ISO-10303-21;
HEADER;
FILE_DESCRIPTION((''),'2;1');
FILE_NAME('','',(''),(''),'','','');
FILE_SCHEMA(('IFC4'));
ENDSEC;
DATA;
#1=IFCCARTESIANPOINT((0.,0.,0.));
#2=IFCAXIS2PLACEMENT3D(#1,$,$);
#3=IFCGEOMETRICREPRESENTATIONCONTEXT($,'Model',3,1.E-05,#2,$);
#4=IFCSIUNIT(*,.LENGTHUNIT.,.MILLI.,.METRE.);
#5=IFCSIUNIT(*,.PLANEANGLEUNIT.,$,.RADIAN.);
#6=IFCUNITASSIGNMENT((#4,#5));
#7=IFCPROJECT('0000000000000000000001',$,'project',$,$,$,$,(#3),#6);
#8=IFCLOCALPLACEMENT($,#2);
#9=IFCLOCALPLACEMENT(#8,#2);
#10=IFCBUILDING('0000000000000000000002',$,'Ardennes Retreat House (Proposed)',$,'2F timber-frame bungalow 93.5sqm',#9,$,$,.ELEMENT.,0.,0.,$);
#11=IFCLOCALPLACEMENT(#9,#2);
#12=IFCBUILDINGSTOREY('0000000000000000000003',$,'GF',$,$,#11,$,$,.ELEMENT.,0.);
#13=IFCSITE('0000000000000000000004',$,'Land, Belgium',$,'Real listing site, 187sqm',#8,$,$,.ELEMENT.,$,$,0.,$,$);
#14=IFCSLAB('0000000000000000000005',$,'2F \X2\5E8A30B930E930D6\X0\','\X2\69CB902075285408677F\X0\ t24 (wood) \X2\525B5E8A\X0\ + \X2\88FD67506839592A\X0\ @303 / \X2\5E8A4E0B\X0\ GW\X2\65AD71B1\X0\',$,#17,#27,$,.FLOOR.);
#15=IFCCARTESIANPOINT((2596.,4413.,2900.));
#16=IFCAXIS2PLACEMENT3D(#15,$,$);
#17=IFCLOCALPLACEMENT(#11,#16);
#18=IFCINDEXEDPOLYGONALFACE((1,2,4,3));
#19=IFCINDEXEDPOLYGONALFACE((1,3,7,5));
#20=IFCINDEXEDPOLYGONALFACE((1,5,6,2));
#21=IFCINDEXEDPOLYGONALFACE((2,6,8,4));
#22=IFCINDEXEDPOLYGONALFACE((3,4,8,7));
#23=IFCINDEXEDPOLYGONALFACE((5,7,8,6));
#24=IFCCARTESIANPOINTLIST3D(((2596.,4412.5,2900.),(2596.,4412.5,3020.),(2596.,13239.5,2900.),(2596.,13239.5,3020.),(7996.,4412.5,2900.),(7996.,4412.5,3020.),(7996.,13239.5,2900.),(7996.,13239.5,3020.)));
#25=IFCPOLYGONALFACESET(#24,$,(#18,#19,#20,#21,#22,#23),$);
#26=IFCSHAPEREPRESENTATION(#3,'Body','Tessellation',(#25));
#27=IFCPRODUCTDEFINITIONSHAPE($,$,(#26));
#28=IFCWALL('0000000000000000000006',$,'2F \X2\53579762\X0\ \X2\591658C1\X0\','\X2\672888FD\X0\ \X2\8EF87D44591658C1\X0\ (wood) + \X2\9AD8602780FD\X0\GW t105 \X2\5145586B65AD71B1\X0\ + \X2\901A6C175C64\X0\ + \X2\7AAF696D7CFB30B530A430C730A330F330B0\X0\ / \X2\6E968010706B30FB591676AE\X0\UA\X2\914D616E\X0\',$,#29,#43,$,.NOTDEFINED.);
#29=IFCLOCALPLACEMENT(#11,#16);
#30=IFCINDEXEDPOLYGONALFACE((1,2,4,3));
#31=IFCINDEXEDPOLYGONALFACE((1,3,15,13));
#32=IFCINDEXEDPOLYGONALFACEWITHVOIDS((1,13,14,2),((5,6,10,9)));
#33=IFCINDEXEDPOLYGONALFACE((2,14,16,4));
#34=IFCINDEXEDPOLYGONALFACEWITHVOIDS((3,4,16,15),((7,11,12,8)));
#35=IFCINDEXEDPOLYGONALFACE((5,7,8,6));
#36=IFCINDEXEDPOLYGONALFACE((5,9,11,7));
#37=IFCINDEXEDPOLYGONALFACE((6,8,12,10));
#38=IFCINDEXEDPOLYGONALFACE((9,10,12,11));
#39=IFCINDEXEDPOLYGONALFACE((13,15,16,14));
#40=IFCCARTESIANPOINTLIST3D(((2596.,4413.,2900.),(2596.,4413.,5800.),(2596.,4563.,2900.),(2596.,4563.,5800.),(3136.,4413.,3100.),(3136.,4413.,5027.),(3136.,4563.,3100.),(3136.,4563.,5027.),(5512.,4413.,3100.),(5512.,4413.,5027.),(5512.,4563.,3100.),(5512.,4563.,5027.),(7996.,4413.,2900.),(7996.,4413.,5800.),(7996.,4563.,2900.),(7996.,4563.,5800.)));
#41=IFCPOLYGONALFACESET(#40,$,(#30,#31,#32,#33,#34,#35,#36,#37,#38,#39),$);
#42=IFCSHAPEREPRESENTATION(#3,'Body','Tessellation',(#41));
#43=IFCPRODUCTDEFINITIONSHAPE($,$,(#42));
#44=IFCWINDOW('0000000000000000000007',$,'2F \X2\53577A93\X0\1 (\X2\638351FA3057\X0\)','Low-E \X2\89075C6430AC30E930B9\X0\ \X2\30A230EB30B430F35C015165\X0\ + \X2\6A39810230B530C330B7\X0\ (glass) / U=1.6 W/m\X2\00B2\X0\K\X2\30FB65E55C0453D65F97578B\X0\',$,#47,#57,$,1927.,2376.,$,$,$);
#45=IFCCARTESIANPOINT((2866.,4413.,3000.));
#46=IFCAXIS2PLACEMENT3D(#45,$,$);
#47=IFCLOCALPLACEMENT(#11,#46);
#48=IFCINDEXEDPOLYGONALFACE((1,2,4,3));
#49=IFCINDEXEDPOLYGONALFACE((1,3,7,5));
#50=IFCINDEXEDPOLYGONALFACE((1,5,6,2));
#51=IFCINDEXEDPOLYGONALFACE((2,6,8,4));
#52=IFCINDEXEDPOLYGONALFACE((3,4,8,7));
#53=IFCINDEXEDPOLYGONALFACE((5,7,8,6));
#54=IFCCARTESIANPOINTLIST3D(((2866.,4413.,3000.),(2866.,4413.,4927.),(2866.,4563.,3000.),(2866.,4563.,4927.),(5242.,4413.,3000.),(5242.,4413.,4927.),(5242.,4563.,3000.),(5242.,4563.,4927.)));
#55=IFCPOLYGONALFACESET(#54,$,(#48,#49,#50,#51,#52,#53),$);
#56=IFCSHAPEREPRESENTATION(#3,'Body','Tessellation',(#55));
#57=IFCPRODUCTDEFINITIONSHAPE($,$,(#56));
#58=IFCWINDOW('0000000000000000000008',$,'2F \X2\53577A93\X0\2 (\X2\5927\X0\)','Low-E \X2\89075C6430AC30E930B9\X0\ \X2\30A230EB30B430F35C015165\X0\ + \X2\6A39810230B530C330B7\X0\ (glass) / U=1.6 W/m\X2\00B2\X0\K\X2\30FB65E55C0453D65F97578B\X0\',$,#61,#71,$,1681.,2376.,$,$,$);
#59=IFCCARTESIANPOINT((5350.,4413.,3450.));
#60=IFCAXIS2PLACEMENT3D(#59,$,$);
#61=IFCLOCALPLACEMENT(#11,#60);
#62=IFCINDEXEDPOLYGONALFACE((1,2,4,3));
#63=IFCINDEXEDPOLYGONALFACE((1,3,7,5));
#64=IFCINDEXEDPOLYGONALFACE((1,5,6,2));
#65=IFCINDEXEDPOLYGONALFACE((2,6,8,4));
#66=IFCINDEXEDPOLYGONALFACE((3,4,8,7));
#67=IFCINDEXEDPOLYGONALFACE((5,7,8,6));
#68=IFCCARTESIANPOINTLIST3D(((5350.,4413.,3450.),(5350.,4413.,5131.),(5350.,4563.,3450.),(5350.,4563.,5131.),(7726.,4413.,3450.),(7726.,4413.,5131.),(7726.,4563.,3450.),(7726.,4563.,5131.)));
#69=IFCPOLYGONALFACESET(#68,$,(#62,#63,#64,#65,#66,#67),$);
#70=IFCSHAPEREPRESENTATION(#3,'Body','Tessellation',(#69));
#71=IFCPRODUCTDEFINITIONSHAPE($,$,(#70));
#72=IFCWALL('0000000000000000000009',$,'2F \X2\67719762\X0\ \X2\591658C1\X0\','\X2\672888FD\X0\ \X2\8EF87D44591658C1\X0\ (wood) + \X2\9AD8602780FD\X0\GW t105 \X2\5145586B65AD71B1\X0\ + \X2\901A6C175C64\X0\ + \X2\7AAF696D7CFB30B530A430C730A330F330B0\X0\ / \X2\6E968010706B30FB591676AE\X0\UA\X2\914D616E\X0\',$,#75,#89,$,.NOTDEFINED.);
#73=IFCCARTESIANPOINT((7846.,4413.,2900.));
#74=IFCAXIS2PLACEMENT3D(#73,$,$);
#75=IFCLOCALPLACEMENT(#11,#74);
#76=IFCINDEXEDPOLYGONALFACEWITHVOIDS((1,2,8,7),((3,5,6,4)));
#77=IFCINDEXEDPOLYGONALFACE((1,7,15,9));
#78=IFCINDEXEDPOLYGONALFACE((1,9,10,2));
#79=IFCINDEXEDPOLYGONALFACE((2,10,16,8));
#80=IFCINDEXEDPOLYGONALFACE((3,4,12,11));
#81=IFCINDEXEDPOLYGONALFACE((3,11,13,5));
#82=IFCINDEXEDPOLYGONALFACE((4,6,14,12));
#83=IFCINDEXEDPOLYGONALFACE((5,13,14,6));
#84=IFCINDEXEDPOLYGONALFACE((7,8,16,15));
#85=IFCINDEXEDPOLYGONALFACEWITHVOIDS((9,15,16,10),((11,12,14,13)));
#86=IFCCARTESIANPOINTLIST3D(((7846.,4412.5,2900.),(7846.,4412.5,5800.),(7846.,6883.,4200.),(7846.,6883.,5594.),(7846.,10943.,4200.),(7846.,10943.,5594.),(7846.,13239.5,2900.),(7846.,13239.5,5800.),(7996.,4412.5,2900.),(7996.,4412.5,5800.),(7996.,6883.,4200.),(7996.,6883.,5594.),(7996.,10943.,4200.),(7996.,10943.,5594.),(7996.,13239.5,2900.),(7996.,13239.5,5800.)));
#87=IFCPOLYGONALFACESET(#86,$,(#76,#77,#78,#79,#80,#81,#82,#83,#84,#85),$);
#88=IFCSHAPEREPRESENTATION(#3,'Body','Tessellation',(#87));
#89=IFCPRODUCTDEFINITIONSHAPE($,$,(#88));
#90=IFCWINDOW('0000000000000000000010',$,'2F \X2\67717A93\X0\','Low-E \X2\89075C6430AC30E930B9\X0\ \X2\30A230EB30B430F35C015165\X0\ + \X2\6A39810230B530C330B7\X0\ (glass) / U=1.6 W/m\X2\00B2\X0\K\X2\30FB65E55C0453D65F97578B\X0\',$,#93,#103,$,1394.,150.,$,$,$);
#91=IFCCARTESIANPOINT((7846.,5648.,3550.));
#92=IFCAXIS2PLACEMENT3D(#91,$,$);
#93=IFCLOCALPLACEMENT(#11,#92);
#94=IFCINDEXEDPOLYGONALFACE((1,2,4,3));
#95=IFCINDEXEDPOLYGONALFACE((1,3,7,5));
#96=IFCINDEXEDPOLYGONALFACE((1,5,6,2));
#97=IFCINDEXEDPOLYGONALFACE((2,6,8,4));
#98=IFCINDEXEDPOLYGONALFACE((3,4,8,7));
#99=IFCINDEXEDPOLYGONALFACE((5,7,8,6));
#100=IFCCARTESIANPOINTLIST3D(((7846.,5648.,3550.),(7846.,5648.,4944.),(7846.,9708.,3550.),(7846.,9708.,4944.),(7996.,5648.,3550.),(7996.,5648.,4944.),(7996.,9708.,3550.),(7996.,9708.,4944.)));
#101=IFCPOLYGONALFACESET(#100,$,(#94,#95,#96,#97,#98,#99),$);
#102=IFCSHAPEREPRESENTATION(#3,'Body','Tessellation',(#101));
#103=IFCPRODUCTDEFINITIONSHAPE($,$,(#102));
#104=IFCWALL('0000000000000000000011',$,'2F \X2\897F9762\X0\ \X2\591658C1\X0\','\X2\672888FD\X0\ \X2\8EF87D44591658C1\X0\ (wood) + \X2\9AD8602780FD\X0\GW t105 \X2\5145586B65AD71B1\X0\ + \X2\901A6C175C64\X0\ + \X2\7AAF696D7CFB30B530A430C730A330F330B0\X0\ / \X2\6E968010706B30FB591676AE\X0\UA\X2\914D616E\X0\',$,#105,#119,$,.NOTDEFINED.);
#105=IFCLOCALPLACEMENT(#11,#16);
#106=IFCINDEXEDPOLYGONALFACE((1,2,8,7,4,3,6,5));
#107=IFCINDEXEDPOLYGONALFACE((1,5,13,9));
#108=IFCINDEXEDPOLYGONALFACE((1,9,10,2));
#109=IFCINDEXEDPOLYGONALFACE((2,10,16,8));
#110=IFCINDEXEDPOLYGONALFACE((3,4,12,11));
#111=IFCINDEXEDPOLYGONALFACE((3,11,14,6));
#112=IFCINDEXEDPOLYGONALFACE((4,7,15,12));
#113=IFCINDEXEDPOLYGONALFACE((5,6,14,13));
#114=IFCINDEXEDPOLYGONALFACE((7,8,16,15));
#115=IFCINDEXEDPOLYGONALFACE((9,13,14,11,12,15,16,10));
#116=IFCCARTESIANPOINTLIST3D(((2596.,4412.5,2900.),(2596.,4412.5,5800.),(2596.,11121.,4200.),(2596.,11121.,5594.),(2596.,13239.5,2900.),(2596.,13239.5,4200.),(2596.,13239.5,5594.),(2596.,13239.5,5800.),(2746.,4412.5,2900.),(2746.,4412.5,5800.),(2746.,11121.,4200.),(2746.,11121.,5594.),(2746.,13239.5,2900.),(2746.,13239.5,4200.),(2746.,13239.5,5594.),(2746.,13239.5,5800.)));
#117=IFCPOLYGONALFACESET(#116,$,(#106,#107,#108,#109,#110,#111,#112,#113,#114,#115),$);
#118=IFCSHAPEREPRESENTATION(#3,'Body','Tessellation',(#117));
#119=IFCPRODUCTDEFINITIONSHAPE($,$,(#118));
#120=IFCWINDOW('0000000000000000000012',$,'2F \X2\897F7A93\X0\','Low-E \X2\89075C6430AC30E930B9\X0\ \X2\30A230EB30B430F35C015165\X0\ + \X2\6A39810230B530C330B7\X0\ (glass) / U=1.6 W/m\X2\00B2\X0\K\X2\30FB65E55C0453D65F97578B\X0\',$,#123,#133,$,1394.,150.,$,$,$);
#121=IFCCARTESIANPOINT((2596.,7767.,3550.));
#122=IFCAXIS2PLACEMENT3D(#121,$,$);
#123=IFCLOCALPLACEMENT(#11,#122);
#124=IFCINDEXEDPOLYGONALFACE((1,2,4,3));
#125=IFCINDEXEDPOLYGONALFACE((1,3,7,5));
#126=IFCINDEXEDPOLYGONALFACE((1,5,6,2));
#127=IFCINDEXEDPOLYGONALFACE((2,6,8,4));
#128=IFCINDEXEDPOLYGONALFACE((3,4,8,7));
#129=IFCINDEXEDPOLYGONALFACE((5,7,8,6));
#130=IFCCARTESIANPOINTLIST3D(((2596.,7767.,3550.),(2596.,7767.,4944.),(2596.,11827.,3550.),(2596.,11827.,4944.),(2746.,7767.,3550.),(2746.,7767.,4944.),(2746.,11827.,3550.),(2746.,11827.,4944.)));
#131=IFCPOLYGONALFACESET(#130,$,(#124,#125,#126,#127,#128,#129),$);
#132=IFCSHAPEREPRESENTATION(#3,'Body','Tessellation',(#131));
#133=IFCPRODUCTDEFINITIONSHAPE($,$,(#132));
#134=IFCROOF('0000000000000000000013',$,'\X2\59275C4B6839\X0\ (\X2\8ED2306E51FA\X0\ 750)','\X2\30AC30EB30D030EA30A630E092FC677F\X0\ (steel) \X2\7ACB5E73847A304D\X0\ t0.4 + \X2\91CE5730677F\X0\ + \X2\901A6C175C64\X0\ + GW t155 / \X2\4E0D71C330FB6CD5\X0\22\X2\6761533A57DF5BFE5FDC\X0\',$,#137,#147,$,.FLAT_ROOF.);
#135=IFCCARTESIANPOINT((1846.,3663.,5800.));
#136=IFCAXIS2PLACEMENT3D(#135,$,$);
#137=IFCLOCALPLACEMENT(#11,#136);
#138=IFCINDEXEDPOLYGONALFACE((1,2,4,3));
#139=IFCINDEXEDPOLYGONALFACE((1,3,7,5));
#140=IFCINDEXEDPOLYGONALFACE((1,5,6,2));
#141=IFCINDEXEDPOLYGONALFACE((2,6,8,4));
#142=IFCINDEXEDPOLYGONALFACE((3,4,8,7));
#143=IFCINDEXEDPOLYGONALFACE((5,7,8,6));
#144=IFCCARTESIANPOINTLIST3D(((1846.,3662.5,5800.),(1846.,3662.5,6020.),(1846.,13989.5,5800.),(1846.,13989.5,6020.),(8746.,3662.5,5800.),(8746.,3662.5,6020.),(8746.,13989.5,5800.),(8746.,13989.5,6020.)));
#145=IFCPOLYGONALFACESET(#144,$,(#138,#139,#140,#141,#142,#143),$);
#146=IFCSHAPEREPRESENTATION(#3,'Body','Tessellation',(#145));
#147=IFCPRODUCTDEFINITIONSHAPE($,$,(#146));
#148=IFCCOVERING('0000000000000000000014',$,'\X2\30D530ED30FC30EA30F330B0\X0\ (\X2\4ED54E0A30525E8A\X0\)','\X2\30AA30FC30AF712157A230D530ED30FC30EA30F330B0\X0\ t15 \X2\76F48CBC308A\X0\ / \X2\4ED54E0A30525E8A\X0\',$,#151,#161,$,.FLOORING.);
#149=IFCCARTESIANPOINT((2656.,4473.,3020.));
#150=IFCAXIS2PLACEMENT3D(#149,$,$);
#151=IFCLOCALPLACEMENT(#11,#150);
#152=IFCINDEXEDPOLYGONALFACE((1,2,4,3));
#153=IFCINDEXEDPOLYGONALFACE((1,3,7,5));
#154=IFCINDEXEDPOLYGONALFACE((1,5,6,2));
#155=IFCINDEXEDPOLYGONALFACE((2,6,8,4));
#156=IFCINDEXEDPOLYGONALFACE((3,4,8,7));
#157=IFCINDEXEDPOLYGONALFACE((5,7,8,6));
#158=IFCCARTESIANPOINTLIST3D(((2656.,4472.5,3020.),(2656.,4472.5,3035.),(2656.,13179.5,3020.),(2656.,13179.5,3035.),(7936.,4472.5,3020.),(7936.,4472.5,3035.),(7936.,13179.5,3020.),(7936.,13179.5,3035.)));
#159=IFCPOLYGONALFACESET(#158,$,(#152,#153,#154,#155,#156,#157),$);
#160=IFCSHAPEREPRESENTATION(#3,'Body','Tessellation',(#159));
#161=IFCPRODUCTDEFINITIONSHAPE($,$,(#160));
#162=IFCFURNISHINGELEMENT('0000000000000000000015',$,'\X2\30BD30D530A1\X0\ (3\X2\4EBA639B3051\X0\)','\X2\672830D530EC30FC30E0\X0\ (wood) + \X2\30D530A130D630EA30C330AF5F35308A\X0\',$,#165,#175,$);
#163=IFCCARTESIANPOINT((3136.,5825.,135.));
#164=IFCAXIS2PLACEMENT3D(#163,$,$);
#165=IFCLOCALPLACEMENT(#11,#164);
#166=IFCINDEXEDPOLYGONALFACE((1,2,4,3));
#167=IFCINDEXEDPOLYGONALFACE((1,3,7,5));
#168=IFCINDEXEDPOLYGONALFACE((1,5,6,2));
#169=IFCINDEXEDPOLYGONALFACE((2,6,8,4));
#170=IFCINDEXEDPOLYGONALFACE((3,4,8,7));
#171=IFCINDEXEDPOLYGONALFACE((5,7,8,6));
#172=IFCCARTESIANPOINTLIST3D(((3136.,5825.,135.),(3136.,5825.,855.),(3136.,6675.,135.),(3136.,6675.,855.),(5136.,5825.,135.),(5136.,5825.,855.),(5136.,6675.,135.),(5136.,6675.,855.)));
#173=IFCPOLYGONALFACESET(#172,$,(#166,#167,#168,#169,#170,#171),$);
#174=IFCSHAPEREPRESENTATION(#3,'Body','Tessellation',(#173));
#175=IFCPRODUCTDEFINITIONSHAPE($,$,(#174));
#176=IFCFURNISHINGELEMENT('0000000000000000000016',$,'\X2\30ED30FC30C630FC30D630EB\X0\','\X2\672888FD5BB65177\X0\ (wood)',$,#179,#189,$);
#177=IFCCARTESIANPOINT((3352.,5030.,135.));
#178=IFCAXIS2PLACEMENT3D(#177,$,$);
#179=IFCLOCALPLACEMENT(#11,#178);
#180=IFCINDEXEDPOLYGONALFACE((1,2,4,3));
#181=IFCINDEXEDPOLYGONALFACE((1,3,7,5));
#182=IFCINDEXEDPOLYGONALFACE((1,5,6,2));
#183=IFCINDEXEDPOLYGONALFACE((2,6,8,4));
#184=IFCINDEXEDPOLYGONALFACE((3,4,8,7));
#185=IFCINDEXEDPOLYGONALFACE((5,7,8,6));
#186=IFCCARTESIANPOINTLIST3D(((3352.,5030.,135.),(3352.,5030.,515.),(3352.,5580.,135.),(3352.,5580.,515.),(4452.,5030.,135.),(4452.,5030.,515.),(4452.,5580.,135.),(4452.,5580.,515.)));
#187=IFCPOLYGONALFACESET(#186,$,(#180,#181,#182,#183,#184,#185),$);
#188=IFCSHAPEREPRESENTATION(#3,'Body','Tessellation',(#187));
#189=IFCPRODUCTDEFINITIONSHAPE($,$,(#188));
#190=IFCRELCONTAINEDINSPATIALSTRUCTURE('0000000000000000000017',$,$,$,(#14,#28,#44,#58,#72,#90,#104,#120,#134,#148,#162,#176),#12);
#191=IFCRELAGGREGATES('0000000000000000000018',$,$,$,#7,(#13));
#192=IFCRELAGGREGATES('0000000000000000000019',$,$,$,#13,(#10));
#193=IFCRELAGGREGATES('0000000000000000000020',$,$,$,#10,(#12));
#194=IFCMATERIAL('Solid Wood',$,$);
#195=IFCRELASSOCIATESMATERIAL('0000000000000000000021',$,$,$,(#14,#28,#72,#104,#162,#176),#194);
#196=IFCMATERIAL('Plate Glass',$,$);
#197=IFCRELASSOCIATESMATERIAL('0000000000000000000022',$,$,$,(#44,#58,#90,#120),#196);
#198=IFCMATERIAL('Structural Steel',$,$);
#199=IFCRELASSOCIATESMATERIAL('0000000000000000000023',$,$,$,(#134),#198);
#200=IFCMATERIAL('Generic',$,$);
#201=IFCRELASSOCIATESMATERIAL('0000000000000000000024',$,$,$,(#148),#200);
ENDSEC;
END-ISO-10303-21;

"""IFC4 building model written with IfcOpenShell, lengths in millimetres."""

from ifc_helpers import new_model, si_unit, frame, frame_2d, origin, place, context, project, spatial, rectangle, extrude, material, element, fill, save


model = new_model("IFC4")

# Units and contexts
model_context = context("Model", 3, precision=1e-05, world=origin())
ifc_project = project(units=[si_unit("LENGTHUNIT", "METRE", prefix="MILLI"), si_unit("PLANEANGLEUNIT", "RADIAN")], contexts=[model_context])

# Site, building, storey
site_placement = place(None, origin())
site = spatial("IfcSite", under=ifc_project, at=site_placement, Name="Land, Belgium", ObjectType="Real listing site, 187sqm", CompositionType="ELEMENT", RefElevation=0.0)
building_placement = place(site_placement, origin())
building = spatial("IfcBuilding", under=site, at=building_placement, Name="Ardennes Retreat House (Proposed)", ObjectType="2F timber-frame bungalow 93.5sqm", CompositionType="ELEMENT", ElevationOfRefHeight=0.0, ElevationOfTerrain=0.0)
storey_placement = place(building_placement, origin())
storey = spatial("IfcBuildingStorey", under=building, at=storey_placement, Name="GF", CompositionType="ELEMENT", Elevation=0.0)

# Slab
ifc_material_1 = material(Name="Solid Wood")
slab_placement = place(storey_placement, frame((2596.0, 4413.0, 2900.0)))
element("IfcSlab", 1, at=slab_placement, inside=storey, material=ifc_material_1, Name="2F 床スラブ", Description="構造用合板 t24 (wood) 剛床 + 製材根太 @303 / 床下 GW断熱", PredefinedType="FLOOR", context=model_context, shape_type="SweptSolid", body=[
    extrude(rectangle(XDim=5400.0, YDim=8827.0, at=frame_2d((2700.0, 4413.0))), frame((2596.0, 4413.0, 2900.0)), (0.0, 0.0, 1.0), 120.0),
])

# Wall, openings, windows
wall_1_placement = place(storey_placement, frame((2596.0, 4413.0, 2900.0)))
wall_1 = element("IfcWall", 2, at=wall_1_placement, inside=storey, material=ifc_material_1, Name="2F 南面 外壁", Description="木製 軸組外壁 (wood) + 高性能GW t105 充填断熱 + 通気層 + 窯業系サイディング / 準耐火・外皮UA配慮", PredefinedType="NOTDEFINED", context=model_context, shape_type="SweptSolid", body=[
    extrude(rectangle(XDim=5400.0, YDim=150.0, at=frame_2d((2700.0, 75.0))), frame((2596.0, 4413.0, 2900.0)), (0.0, 0.0, 1.0), 2900.0),
])
opening_1_placement = place(storey_placement, frame((2866.0, 4413.0, 3000.0)))
opening_1 = element("IfcOpeningElement", 3, at=opening_1_placement, cuts=wall_1, PredefinedType="NOTDEFINED", context=model_context, shape_type="SweptSolid", body=[
    extrude(rectangle(XDim=2376.0, YDim=150.0, at=frame_2d((1188.0, 75.0))), frame((2866.0, 4413.0, 3000.0)), (0.0, 0.0, 1.0), 1927.0),
])
opening_2_placement = place(storey_placement, frame((5350.0, 4413.0, 3450.0)))
opening_2 = element("IfcOpeningElement", 4, at=opening_2_placement, cuts=wall_1, PredefinedType="NOTDEFINED", context=model_context, shape_type="SweptSolid", body=[
    extrude(rectangle(XDim=2376.0, YDim=150.0, at=frame_2d((1188.0, 75.0))), frame((5350.0, 4413.0, 3450.0)), (0.0, 0.0, 1.0), 1681.0),
])
ifc_material_2 = material(Name="Plate Glass")
window_1_placement = place(storey_placement, frame((2866.0, 4413.0, 3000.0)))
window_1 = element("IfcWindow", 5, at=window_1_placement, inside=storey, material=ifc_material_2, Name="2F 南窓1 (掃出し)", Description="Low-E 複層ガラス アルゴン封入 + 樹脂サッシ (glass) / U=1.6 W/m²K・日射取得型", OverallHeight=1927.0, OverallWidth=2376.0, context=model_context, shape_type="SweptSolid", body=[
    extrude(rectangle(XDim=2376.0, YDim=150.0, at=frame_2d((1188.0, 75.0))), frame((2866.0, 4413.0, 3000.0)), (0.0, 0.0, 1.0), 1927.0),
])
fill(opening_1, window_1)
window_2_placement = place(storey_placement, frame((5350.0, 4413.0, 3450.0)))
window_2 = element("IfcWindow", 6, at=window_2_placement, inside=storey, material=ifc_material_2, Name="2F 南窓2 (大)", Description="Low-E 複層ガラス アルゴン封入 + 樹脂サッシ (glass) / U=1.6 W/m²K・日射取得型", OverallHeight=1681.0, OverallWidth=2376.0, context=model_context, shape_type="SweptSolid", body=[
    extrude(rectangle(XDim=2376.0, YDim=150.0, at=frame_2d((1188.0, 75.0))), frame((5350.0, 4413.0, 3450.0)), (0.0, 0.0, 1.0), 1681.0),
])
fill(opening_2, window_2)

# Walls, openings, windows
wall_2_placement = place(storey_placement, frame((7846.0, 4413.0, 2900.0)))
wall_2 = element("IfcWall", 7, at=wall_2_placement, inside=storey, material=ifc_material_1, Name="2F 東面 外壁", Description="木製 軸組外壁 (wood) + 高性能GW t105 充填断熱 + 通気層 + 窯業系サイディング / 準耐火・外皮UA配慮", PredefinedType="NOTDEFINED", context=model_context, shape_type="SweptSolid", body=[
    extrude(rectangle(XDim=150.0, YDim=8827.0, at=frame_2d((75.0, 4413.0))), frame((7846.0, 4413.0, 2900.0)), (0.0, 0.0, 1.0), 2900.0),
])
opening_3_placement = place(storey_placement, frame((7846.0, 5648.0, 3550.0)))
opening_3 = element("IfcOpeningElement", 8, at=opening_3_placement, cuts=wall_2, PredefinedType="NOTDEFINED", context=model_context, shape_type="SweptSolid", body=[
    extrude(rectangle(XDim=150.0, YDim=4060.0, at=frame_2d((75.0, 2030.0))), frame((7846.0, 5648.0, 3550.0)), (0.0, 0.0, 1.0), 1394.0),
])
window_3_placement = place(storey_placement, frame((7846.0, 5648.0, 3550.0)))
window_3 = element("IfcWindow", 9, at=window_3_placement, inside=storey, material=ifc_material_2, Name="2F 東窓", Description="Low-E 複層ガラス アルゴン封入 + 樹脂サッシ (glass) / U=1.6 W/m²K・日射取得型", OverallHeight=1394.0, OverallWidth=150.0, context=model_context, shape_type="SweptSolid", body=[
    extrude(rectangle(XDim=150.0, YDim=4060.0, at=frame_2d((75.0, 2030.0))), frame((7846.0, 5648.0, 3550.0)), (0.0, 0.0, 1.0), 1394.0),
])
fill(opening_3, window_3)
wall_3_placement = place(storey_placement, frame((2596.0, 4413.0, 2900.0)))
wall_3 = element("IfcWall", 10, at=wall_3_placement, inside=storey, material=ifc_material_1, Name="2F 西面 外壁", Description="木製 軸組外壁 (wood) + 高性能GW t105 充填断熱 + 通気層 + 窯業系サイディング / 準耐火・外皮UA配慮", PredefinedType="NOTDEFINED", context=model_context, shape_type="SweptSolid", body=[
    extrude(rectangle(XDim=150.0, YDim=8827.0, at=frame_2d((75.0, 4413.0))), frame((2596.0, 4413.0, 2900.0)), (0.0, 0.0, 1.0), 2900.0),
])
opening_4_placement = place(storey_placement, frame((2596.0, 7767.0, 3550.0)))
opening_4 = element("IfcOpeningElement", 11, at=opening_4_placement, cuts=wall_3, PredefinedType="NOTDEFINED", context=model_context, shape_type="SweptSolid", body=[
    extrude(rectangle(XDim=150.0, YDim=4060.0, at=frame_2d((75.0, 2030.0))), frame((2596.0, 7767.0, 3550.0)), (0.0, 0.0, 1.0), 1394.0),
])
window_4_placement = place(storey_placement, frame((2596.0, 7767.0, 3550.0)))
window_4 = element("IfcWindow", 12, at=window_4_placement, inside=storey, material=ifc_material_2, Name="2F 西窓", Description="Low-E 複層ガラス アルゴン封入 + 樹脂サッシ (glass) / U=1.6 W/m²K・日射取得型", OverallHeight=1394.0, OverallWidth=150.0, context=model_context, shape_type="SweptSolid", body=[
    extrude(rectangle(XDim=150.0, YDim=4060.0, at=frame_2d((75.0, 2030.0))), frame((2596.0, 7767.0, 3550.0)), (0.0, 0.0, 1.0), 1394.0),
])
fill(opening_4, window_4)

# Roof
ifc_material_3 = material(Name="Structural Steel")
roof_placement = place(storey_placement, frame((1846.0, 3663.0, 5800.0)))
element("IfcRoof", 13, at=roof_placement, inside=storey, material=ifc_material_3, Name="大屋根 (軒の出 750)", Description="ガルバリウム鋼板 (steel) 立平葺き t0.4 + 野地板 + 通気層 + GW t155 / 不燃・法22条区域対応", PredefinedType="FLAT_ROOF", context=model_context, shape_type="SweptSolid", body=[
    extrude(rectangle(XDim=6900.0, YDim=10327.0, at=frame_2d((3450.0, 5163.0))), frame((1846.0, 3663.0, 5800.0)), (0.0, 0.0, 1.0), 220.0),
])

# Covering
ifc_material_4 = material(Name="Generic")
covering_placement = place(storey_placement, frame((2656.0, 4473.0, 3020.0)))
element("IfcCovering", 14, at=covering_placement, inside=storey, material=ifc_material_4, Name="フローリング (仕上げ床)", Description="オーク無垢フローリング t15 直貼り / 仕上げ床", PredefinedType="FLOORING", context=model_context, shape_type="SweptSolid", body=[
    extrude(rectangle(XDim=5280.0, YDim=8707.0, at=frame_2d((2640.0, 4353.0))), frame((2656.0, 4473.0, 3020.0)), (0.0, 0.0, 1.0), 15.0),
])

# Furnishing elements
furnishing_1_placement = place(storey_placement, frame((3136.0, 5825.0, 135.0)))
element("IfcFurnishingElement", 15, at=furnishing_1_placement, inside=storey, material=ifc_material_1, Name="ソファ (3人掛け)", Description="木フレーム (wood) + ファブリック張り", context=model_context, shape_type="SweptSolid", body=[
    extrude(rectangle(XDim=2000.0, YDim=850.0, at=frame_2d((1000.0, 425.0))), frame((3136.0, 5825.0, 135.0)), (0.0, 0.0, 1.0), 720.0),
])
furnishing_2_placement = place(storey_placement, frame((3352.0, 5030.0, 135.0)))
element("IfcFurnishingElement", 16, at=furnishing_2_placement, inside=storey, material=ifc_material_1, Name="ローテーブル", Description="木製家具 (wood)", context=model_context, shape_type="SweptSolid", body=[
    extrude(rectangle(XDim=1100.0, YDim=550.0, at=frame_2d((550.0, 275.0))), frame((3352.0, 5030.0, 135.0)), (0.0, 0.0, 1.0), 380.0),
])

save(model, "model.ifc")
